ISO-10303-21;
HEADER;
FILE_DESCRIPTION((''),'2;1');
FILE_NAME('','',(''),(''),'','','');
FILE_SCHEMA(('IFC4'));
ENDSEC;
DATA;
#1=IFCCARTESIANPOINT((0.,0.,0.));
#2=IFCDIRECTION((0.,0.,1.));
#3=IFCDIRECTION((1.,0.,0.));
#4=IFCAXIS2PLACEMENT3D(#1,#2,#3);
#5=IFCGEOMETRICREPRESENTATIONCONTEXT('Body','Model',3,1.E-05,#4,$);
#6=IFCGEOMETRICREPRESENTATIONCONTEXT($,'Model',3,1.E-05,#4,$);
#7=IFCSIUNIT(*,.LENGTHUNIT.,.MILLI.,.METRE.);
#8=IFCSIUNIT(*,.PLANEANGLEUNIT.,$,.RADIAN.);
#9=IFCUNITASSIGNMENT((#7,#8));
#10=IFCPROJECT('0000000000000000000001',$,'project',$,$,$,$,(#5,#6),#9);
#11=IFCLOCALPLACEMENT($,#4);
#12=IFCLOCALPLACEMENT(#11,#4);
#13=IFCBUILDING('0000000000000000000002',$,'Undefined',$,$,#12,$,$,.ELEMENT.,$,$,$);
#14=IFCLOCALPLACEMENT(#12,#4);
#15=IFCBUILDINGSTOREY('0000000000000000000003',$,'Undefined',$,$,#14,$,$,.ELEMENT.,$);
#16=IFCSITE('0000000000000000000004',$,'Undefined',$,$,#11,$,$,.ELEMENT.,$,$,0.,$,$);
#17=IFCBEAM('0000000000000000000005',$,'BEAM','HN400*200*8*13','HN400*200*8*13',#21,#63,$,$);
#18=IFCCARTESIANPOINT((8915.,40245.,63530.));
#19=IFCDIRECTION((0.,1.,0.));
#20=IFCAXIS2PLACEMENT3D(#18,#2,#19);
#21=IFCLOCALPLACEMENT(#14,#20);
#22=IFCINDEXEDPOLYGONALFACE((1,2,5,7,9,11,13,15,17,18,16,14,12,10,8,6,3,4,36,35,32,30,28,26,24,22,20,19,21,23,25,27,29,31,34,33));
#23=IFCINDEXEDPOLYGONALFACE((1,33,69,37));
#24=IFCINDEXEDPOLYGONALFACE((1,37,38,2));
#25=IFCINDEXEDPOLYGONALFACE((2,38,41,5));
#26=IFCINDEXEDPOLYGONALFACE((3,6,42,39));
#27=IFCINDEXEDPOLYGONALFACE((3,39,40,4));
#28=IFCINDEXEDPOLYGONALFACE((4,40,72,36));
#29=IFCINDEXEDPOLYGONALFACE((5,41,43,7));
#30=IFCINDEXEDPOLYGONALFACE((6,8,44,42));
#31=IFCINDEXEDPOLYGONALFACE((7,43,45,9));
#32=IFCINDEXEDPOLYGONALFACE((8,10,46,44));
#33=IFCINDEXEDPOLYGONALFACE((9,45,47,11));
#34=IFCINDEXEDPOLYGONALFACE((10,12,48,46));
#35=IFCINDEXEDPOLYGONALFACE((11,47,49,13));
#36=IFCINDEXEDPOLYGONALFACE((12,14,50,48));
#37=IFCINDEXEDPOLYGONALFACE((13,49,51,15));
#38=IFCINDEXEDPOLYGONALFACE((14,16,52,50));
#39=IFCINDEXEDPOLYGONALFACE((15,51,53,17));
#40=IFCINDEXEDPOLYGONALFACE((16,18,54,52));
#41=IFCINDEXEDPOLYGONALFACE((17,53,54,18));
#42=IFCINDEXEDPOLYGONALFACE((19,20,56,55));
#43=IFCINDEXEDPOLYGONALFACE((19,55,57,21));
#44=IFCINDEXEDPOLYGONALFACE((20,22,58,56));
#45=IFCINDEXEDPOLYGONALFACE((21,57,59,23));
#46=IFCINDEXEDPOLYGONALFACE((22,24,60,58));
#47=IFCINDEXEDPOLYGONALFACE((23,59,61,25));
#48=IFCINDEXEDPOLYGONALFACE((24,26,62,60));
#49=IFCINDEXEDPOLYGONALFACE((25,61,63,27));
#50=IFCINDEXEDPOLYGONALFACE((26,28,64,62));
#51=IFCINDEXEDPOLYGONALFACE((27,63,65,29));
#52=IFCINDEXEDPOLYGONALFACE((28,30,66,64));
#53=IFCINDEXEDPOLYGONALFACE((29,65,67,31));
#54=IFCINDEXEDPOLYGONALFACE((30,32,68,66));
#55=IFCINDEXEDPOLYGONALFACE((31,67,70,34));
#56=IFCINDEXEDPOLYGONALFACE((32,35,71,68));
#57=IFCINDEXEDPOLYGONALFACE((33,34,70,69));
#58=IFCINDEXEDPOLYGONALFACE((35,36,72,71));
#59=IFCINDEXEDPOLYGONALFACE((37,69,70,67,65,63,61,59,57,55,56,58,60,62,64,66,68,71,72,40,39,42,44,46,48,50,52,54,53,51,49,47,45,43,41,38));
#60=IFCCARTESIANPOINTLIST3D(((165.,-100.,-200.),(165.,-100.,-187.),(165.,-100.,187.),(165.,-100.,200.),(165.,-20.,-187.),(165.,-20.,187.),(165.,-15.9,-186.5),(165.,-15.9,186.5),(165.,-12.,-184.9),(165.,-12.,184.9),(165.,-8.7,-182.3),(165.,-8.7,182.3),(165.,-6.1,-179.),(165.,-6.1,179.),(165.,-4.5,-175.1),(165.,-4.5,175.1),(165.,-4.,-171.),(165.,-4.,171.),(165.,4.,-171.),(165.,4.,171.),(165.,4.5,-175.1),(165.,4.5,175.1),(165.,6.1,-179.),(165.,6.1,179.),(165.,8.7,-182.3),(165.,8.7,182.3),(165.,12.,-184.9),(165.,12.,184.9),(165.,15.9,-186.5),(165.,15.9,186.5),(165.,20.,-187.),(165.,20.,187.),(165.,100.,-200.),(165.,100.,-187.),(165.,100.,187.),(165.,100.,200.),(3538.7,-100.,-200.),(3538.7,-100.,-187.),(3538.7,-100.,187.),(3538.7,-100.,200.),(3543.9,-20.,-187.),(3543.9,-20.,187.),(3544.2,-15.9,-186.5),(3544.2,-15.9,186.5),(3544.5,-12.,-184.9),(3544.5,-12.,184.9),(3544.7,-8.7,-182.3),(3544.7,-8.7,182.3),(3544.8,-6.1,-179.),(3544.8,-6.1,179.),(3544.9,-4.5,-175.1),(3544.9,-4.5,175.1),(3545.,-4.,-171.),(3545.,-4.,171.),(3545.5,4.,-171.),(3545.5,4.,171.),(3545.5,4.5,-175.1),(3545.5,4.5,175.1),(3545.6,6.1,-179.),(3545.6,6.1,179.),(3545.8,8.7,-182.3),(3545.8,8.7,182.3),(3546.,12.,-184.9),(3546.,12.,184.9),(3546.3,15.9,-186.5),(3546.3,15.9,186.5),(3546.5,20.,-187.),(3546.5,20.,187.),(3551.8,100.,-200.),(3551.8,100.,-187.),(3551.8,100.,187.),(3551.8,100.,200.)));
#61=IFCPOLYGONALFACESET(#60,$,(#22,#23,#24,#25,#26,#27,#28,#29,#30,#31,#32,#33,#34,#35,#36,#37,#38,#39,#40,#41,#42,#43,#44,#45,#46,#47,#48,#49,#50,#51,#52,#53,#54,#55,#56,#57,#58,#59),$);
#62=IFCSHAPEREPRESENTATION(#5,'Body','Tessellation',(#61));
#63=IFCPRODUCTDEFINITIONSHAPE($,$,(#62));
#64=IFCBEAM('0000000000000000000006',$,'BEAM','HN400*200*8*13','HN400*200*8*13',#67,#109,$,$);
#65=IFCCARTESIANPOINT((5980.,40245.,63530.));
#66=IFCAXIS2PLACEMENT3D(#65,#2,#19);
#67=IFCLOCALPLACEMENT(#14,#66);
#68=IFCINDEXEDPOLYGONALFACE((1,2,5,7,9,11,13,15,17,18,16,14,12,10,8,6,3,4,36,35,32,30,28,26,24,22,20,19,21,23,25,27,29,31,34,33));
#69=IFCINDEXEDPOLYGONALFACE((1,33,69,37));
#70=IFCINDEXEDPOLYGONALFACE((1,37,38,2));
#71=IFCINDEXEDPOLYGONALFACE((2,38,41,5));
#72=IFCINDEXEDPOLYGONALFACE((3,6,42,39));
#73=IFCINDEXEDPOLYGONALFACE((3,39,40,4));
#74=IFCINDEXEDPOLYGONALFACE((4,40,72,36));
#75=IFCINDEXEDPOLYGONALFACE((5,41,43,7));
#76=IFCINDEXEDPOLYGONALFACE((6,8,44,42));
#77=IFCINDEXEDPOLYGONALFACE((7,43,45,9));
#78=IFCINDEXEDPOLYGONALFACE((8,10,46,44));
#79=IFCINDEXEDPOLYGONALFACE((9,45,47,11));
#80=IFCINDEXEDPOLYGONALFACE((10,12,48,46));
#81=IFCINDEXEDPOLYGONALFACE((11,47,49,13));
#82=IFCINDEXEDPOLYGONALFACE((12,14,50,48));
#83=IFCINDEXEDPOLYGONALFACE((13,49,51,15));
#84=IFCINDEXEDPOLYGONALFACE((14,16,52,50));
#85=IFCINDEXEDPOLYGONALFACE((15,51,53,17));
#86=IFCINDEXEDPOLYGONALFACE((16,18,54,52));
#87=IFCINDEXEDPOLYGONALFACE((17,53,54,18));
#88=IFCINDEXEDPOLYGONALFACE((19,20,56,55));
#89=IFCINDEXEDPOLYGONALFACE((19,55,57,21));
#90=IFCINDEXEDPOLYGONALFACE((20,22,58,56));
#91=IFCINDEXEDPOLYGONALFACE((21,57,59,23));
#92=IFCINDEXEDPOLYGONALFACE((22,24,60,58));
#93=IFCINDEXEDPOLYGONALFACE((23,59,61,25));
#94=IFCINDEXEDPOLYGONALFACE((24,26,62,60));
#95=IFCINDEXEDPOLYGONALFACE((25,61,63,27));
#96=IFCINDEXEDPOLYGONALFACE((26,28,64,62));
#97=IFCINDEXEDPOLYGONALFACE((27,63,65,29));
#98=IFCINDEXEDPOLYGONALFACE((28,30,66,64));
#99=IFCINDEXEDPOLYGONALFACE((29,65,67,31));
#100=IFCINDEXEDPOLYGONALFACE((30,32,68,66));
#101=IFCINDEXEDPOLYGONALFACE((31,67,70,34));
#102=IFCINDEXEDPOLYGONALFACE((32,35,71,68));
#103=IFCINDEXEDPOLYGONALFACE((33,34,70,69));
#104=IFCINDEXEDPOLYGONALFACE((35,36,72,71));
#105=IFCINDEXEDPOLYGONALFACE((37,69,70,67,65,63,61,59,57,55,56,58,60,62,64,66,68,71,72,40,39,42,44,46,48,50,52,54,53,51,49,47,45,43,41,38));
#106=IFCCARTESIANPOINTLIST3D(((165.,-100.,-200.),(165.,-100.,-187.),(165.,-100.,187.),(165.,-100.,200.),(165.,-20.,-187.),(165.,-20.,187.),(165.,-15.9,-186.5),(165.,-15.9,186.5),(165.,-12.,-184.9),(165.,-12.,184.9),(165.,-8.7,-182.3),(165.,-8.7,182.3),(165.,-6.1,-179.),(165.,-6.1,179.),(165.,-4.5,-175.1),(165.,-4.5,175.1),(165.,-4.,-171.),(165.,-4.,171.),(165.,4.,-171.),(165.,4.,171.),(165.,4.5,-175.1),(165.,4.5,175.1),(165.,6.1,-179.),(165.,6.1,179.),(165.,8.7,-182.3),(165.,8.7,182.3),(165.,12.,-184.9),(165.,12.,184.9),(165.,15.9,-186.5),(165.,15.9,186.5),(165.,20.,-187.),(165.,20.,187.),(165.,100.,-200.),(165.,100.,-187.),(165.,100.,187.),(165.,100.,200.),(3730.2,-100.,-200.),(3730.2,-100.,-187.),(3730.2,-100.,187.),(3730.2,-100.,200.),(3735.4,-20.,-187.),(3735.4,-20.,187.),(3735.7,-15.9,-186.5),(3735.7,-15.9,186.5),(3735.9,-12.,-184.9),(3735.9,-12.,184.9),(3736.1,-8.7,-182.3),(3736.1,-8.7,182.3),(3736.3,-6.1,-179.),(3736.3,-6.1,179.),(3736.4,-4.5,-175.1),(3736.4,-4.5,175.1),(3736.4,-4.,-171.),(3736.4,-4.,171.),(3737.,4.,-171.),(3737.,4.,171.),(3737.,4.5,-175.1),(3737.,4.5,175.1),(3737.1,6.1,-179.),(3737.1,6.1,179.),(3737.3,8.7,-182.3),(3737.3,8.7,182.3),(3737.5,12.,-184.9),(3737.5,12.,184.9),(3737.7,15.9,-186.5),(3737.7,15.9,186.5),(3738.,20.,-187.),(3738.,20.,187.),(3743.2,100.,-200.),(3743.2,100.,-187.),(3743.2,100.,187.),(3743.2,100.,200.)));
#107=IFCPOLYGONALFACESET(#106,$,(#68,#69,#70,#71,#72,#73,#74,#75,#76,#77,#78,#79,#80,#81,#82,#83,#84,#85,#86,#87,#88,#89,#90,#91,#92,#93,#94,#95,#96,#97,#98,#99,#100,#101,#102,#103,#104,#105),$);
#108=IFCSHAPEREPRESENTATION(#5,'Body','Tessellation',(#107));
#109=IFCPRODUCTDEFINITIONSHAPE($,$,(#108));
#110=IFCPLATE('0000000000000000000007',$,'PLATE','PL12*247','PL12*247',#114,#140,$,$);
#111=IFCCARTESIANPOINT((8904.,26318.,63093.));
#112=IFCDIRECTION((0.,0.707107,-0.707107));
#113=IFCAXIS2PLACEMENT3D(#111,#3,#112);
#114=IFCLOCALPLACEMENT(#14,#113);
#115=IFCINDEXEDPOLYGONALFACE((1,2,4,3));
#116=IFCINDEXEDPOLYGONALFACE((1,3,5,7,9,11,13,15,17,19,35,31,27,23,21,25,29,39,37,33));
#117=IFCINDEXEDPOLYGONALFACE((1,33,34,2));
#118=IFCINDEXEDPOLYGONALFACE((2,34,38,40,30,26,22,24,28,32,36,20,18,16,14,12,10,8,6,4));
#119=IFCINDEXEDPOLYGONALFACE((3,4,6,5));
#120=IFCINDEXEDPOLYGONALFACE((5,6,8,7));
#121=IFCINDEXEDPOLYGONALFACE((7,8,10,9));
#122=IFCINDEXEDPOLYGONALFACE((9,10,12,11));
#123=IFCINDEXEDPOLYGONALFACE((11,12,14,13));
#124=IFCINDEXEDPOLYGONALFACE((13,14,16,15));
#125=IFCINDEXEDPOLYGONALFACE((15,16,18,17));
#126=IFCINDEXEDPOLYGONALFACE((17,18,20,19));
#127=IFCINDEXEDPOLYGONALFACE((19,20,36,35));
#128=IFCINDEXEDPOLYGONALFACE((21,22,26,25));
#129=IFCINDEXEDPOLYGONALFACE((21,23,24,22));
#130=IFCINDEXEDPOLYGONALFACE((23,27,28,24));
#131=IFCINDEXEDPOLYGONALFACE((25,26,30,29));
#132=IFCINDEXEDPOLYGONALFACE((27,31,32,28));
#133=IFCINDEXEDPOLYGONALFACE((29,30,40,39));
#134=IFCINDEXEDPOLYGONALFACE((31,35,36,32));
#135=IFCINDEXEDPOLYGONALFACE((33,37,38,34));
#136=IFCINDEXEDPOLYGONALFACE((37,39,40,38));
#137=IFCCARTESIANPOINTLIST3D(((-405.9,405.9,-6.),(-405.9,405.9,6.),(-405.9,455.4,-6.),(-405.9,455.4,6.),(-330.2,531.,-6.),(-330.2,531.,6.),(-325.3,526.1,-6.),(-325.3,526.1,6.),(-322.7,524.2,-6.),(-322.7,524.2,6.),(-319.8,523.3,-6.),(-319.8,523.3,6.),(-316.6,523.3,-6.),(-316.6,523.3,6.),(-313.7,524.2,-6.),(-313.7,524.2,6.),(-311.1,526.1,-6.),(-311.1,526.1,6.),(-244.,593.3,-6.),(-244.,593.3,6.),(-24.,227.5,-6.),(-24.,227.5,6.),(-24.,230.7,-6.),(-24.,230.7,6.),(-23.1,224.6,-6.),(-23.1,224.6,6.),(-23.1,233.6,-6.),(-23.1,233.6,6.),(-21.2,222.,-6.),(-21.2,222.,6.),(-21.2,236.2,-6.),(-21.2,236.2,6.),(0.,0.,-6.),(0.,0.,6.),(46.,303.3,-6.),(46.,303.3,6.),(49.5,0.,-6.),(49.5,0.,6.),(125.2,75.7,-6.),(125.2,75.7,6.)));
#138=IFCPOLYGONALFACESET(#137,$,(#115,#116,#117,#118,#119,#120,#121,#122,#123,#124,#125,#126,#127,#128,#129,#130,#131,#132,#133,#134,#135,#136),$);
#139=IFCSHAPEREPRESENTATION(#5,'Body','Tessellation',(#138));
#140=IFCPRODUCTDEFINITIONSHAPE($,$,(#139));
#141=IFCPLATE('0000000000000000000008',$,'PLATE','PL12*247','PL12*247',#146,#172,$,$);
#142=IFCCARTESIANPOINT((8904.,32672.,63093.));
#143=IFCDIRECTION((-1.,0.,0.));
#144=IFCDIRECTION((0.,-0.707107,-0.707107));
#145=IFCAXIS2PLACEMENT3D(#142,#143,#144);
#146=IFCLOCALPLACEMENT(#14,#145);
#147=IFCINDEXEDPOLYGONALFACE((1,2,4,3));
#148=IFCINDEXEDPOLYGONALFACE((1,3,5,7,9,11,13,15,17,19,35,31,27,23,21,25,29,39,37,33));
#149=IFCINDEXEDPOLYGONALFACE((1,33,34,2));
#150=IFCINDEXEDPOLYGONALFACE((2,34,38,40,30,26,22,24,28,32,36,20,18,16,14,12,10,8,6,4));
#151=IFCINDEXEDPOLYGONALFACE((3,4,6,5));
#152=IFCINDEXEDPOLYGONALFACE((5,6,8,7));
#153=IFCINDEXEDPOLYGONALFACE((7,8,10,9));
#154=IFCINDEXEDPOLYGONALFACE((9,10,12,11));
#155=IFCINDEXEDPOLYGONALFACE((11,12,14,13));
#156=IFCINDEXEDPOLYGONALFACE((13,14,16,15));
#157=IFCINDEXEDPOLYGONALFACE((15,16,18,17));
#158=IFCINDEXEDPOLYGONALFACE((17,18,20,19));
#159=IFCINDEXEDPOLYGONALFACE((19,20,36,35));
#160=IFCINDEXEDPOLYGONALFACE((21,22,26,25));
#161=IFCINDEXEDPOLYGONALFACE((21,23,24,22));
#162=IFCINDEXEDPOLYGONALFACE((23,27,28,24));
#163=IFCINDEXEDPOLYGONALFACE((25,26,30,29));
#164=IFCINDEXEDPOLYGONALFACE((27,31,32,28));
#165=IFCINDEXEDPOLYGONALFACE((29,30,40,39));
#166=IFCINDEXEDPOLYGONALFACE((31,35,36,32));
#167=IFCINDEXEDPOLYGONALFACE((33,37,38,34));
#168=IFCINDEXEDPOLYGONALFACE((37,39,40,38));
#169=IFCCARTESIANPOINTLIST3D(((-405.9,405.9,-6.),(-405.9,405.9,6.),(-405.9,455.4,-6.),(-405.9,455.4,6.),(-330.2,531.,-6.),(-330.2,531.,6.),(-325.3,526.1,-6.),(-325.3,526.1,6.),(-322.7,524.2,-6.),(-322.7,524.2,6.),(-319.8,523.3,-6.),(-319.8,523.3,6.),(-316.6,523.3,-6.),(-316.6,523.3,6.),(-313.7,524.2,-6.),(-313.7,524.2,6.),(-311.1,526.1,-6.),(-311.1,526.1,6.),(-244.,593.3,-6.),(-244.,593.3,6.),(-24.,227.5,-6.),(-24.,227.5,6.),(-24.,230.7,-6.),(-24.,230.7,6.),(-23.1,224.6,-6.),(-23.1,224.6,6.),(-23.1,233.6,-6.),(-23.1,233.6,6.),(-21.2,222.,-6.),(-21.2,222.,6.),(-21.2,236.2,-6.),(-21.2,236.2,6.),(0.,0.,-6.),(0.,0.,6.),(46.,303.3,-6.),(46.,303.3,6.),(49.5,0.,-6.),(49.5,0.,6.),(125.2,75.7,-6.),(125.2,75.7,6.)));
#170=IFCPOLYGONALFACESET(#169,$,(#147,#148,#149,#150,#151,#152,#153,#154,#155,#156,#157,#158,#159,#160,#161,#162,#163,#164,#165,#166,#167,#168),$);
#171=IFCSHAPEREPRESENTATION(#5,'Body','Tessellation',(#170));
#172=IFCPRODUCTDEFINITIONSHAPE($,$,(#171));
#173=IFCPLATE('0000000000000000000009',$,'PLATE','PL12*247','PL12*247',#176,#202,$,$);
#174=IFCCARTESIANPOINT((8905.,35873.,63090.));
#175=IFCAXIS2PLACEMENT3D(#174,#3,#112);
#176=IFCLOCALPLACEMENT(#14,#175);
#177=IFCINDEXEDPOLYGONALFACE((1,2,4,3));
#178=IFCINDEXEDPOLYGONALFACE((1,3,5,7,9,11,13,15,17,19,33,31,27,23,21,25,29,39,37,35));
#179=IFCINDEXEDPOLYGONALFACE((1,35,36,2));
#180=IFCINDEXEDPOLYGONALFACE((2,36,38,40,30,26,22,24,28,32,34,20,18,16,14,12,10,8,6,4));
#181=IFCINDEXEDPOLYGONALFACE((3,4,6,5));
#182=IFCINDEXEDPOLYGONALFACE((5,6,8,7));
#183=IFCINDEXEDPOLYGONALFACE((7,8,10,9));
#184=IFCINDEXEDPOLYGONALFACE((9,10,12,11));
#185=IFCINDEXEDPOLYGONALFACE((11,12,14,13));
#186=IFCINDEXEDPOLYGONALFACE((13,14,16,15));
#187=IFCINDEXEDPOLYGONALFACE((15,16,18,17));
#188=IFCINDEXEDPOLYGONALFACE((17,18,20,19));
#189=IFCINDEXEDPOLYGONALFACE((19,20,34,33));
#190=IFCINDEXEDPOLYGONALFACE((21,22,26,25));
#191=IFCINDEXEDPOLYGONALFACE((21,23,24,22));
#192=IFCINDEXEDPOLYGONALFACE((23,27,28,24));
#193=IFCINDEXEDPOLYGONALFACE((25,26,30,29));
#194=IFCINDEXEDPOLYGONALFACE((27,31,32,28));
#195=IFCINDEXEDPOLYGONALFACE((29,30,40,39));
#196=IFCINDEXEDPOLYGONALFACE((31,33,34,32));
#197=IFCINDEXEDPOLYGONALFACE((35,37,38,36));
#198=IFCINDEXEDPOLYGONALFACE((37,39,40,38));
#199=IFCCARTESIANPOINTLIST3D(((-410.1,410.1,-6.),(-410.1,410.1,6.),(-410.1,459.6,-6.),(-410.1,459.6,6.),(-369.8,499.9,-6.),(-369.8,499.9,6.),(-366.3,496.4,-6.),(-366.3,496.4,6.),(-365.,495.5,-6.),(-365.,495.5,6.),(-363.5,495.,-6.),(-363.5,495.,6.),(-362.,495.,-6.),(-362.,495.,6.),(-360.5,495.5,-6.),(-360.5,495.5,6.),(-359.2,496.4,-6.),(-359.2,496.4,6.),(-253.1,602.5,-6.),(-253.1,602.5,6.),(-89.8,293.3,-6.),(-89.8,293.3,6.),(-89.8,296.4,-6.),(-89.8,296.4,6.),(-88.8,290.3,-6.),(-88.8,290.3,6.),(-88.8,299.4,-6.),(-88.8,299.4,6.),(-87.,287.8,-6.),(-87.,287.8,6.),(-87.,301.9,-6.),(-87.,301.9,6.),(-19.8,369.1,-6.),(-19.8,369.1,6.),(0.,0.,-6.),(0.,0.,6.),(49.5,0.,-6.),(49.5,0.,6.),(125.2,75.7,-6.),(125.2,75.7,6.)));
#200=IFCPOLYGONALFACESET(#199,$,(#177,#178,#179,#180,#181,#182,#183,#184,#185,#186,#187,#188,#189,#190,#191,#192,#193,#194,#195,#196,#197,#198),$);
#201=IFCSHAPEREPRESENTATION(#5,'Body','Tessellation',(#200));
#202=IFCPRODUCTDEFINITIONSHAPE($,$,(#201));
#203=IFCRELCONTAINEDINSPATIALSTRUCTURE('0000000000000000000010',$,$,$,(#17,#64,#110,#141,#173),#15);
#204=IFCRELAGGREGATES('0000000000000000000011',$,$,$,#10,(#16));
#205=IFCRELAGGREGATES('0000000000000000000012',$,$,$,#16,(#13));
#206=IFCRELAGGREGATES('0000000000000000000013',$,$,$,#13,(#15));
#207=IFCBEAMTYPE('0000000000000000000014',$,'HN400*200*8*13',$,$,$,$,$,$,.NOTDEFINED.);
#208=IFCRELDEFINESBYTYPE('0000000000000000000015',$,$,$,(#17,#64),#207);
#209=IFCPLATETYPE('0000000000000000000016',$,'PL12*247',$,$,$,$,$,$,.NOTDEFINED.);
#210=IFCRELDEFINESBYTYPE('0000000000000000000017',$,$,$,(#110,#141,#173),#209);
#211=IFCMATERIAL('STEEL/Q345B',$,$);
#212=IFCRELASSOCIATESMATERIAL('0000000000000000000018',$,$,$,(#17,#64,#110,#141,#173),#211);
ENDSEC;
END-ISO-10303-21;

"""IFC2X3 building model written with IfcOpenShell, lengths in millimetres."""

from ifc_helpers import new_model, si_unit, frame, origin_with_axes, origin_2d_with_axis, place, context, project, spatial, polyline, i_section, outline, extrude, clip, halfspace, material, type_object, element, save


model = new_model("IFC2X3")

# Units and contexts
model_context_1 = context("Model", 3, precision=1e-05, world=origin_with_axes(), identifier="Body")
model_context_2 = context("Model", 3, precision=1e-05, world=origin_with_axes())
ifc_project = project(units=[si_unit("LENGTHUNIT", "METRE", prefix="MILLI"), si_unit("PLANEANGLEUNIT", "RADIAN")], contexts=[model_context_1, model_context_2])

# Site, building, storey
site_placement = place(None, origin_with_axes())
site = spatial("IfcSite", under=ifc_project, at=site_placement, Name="Undefined", CompositionType="ELEMENT", RefElevation=0.0)
building_placement = place(site_placement, origin_with_axes())
building = spatial("IfcBuilding", under=site, at=building_placement, Name="Undefined", CompositionType="ELEMENT")
storey_placement = place(building_placement, origin_with_axes())
storey = spatial("IfcBuildingStorey", under=building, at=storey_placement, Name="Undefined", CompositionType="ELEMENT")

# Shared definitions
ifc_material_1 = material(Name="STEEL/Q345B")

# Beams
beam_type_1 = type_object("IfcBeamType", Name="HN400*200*8*13", PredefinedType="NOTDEFINED")
beam_1_placement = place(storey_placement, frame((8915.0, 40245.0, 63530.0), z_axis=(0.0, 0.0, 1.0), x_axis=(0.0, 1.0, 0.0)))
element("IfcBeam", 1, at=beam_1_placement, inside=storey, type_object=beam_type_1, material=ifc_material_1, Name="BEAM", Description="HN400*200*8*13", ObjectType="HN400*200*8*13", context=model_context_1, shape_type="Clipping", body=[
    clip(clip(extrude(i_section(OverallWidth=200.0, OverallDepth=400.0, WebThickness=8.0, FlangeThickness=13.0, FilletRadius=16.0, at=origin_2d_with_axis()), frame((3551.8, 0.0, 0.0), z_axis=(-1.0, 0.0, 0.0), x_axis=(0.0, -1.0, 0.0)), (0.0, 0.0, 1.0), 3386.8), halfspace(frame((3546.1, 13.2, 300.0), z_axis=(0.997873, -0.065183, 0.0), x_axis=(0.065184, 0.997873, 0.0)), False)), halfspace(frame((165.0, 0.0, 300.0), z_axis=(-1.0, 0.0, 0.0), x_axis=(0.0, -1.0, 0.0)), False)),
])
beam_2_placement = place(storey_placement, frame((5980.0, 40245.0, 63530.0), z_axis=(0.0, 0.0, 1.0), x_axis=(0.0, 1.0, 0.0)))
element("IfcBeam", 2, at=beam_2_placement, inside=storey, type_object=beam_type_1, material=ifc_material_1, Name="BEAM", Description="HN400*200*8*13", ObjectType="HN400*200*8*13", context=model_context_1, shape_type="Clipping", body=[
    clip(clip(extrude(i_section(OverallWidth=200.0, OverallDepth=400.0, WebThickness=8.0, FlangeThickness=13.0, FilletRadius=16.0, at=origin_2d_with_axis()), frame((3743.3, 0.0, 0.0), z_axis=(-1.0, 0.0, 0.0), x_axis=(0.0, -1.0, 0.0)), (0.0, 0.0, 1.0), 3578.3), halfspace(frame((3737.6, 13.2, 300.0), z_axis=(0.997873, -0.065183, 0.0), x_axis=(0.065184, 0.997873, 0.0)), False)), halfspace(frame((165.0, 0.0, 300.0), z_axis=(-1.0, 0.0, 0.0), x_axis=(0.0, -1.0, 0.0)), False)),
])

# Plates
plate_type_1 = type_object("IfcPlateType", Name="PL12*247", PredefinedType="NOTDEFINED")
for number, where, z_axis, x_axis, name in (
    (3, (8904.0, 26318.0, 63093.0), (1.0, 0.0, 0.0), (0.0, 0.707107, -0.707107), "PLATE"),
    (4, (8904.0, 32672.0, 63093.0), (-1.0, 0.0, 0.0), (0.0, -0.707107, -0.707107), "PLATE"),
):
    element("IfcPlate", number, at=place(storey_placement, frame(where, z_axis=z_axis, x_axis=x_axis)), inside=storey, type_object=plate_type_1, material=ifc_material_1, Name=name, Description="PL12*247", ObjectType="PL12*247", context=model_context_1, shape_type="SweptSolid", body=[
        extrude(outline(polyline([(0.0, 0.0), (49.5, 0.0), (125.2, 75.7), (-21.2, 222.0), (-23.1, 224.6), (-24.0, 227.5), (-24.0, 230.7), (-23.1, 233.6), (-21.2, 236.2), (46.0, 303.3), (-244.0, 593.3), (-311.1, 526.1), (-313.7, 524.2), (-316.6, 523.3), (-319.8, 523.3), (-322.7, 524.2), (-325.3, 526.1), (-330.2, 531.0), (-405.9, 455.4), (-405.9, 405.9), (0.0, 0.0)])), frame((0.0, 0.0, -6.0), z_axis=(0.0, 0.0, 1.0), x_axis=(1.0, 0.0, 0.0)), (0.0, 0.0, 1.0), 12.0),
    ])
plate_1_placement = place(storey_placement, frame((8905.0, 35873.0, 63090.0), z_axis=(1.0, 0.0, 0.0), x_axis=(0.0, 0.707107, -0.707107)))
element("IfcPlate", 5, at=plate_1_placement, inside=storey, type_object=plate_type_1, material=ifc_material_1, Name="PLATE", Description="PL12*247", ObjectType="PL12*247", context=model_context_1, shape_type="SweptSolid", body=[
    extrude(outline(polyline([(0.0, 0.0), (49.5, 0.0), (125.2, 75.7), (-87.0, 287.8), (-88.8, 290.3), (-89.8, 293.3), (-89.8, 296.4), (-88.8, 299.4), (-87.0, 301.9), (-19.8, 369.1), (-253.1, 602.5), (-359.2, 496.4), (-360.5, 495.5), (-362.0, 495.0), (-363.5, 495.0), (-365.0, 495.5), (-366.3, 496.4), (-369.8, 499.9), (-410.1, 459.6), (-410.1, 410.1), (0.0, 0.0)])), frame((0.0, 0.0, -6.0), z_axis=(0.0, 0.0, 1.0), x_axis=(1.0, 0.0, 0.0)), (0.0, 0.0, 1.0), 12.0),
])

save(model, "model.ifc")
